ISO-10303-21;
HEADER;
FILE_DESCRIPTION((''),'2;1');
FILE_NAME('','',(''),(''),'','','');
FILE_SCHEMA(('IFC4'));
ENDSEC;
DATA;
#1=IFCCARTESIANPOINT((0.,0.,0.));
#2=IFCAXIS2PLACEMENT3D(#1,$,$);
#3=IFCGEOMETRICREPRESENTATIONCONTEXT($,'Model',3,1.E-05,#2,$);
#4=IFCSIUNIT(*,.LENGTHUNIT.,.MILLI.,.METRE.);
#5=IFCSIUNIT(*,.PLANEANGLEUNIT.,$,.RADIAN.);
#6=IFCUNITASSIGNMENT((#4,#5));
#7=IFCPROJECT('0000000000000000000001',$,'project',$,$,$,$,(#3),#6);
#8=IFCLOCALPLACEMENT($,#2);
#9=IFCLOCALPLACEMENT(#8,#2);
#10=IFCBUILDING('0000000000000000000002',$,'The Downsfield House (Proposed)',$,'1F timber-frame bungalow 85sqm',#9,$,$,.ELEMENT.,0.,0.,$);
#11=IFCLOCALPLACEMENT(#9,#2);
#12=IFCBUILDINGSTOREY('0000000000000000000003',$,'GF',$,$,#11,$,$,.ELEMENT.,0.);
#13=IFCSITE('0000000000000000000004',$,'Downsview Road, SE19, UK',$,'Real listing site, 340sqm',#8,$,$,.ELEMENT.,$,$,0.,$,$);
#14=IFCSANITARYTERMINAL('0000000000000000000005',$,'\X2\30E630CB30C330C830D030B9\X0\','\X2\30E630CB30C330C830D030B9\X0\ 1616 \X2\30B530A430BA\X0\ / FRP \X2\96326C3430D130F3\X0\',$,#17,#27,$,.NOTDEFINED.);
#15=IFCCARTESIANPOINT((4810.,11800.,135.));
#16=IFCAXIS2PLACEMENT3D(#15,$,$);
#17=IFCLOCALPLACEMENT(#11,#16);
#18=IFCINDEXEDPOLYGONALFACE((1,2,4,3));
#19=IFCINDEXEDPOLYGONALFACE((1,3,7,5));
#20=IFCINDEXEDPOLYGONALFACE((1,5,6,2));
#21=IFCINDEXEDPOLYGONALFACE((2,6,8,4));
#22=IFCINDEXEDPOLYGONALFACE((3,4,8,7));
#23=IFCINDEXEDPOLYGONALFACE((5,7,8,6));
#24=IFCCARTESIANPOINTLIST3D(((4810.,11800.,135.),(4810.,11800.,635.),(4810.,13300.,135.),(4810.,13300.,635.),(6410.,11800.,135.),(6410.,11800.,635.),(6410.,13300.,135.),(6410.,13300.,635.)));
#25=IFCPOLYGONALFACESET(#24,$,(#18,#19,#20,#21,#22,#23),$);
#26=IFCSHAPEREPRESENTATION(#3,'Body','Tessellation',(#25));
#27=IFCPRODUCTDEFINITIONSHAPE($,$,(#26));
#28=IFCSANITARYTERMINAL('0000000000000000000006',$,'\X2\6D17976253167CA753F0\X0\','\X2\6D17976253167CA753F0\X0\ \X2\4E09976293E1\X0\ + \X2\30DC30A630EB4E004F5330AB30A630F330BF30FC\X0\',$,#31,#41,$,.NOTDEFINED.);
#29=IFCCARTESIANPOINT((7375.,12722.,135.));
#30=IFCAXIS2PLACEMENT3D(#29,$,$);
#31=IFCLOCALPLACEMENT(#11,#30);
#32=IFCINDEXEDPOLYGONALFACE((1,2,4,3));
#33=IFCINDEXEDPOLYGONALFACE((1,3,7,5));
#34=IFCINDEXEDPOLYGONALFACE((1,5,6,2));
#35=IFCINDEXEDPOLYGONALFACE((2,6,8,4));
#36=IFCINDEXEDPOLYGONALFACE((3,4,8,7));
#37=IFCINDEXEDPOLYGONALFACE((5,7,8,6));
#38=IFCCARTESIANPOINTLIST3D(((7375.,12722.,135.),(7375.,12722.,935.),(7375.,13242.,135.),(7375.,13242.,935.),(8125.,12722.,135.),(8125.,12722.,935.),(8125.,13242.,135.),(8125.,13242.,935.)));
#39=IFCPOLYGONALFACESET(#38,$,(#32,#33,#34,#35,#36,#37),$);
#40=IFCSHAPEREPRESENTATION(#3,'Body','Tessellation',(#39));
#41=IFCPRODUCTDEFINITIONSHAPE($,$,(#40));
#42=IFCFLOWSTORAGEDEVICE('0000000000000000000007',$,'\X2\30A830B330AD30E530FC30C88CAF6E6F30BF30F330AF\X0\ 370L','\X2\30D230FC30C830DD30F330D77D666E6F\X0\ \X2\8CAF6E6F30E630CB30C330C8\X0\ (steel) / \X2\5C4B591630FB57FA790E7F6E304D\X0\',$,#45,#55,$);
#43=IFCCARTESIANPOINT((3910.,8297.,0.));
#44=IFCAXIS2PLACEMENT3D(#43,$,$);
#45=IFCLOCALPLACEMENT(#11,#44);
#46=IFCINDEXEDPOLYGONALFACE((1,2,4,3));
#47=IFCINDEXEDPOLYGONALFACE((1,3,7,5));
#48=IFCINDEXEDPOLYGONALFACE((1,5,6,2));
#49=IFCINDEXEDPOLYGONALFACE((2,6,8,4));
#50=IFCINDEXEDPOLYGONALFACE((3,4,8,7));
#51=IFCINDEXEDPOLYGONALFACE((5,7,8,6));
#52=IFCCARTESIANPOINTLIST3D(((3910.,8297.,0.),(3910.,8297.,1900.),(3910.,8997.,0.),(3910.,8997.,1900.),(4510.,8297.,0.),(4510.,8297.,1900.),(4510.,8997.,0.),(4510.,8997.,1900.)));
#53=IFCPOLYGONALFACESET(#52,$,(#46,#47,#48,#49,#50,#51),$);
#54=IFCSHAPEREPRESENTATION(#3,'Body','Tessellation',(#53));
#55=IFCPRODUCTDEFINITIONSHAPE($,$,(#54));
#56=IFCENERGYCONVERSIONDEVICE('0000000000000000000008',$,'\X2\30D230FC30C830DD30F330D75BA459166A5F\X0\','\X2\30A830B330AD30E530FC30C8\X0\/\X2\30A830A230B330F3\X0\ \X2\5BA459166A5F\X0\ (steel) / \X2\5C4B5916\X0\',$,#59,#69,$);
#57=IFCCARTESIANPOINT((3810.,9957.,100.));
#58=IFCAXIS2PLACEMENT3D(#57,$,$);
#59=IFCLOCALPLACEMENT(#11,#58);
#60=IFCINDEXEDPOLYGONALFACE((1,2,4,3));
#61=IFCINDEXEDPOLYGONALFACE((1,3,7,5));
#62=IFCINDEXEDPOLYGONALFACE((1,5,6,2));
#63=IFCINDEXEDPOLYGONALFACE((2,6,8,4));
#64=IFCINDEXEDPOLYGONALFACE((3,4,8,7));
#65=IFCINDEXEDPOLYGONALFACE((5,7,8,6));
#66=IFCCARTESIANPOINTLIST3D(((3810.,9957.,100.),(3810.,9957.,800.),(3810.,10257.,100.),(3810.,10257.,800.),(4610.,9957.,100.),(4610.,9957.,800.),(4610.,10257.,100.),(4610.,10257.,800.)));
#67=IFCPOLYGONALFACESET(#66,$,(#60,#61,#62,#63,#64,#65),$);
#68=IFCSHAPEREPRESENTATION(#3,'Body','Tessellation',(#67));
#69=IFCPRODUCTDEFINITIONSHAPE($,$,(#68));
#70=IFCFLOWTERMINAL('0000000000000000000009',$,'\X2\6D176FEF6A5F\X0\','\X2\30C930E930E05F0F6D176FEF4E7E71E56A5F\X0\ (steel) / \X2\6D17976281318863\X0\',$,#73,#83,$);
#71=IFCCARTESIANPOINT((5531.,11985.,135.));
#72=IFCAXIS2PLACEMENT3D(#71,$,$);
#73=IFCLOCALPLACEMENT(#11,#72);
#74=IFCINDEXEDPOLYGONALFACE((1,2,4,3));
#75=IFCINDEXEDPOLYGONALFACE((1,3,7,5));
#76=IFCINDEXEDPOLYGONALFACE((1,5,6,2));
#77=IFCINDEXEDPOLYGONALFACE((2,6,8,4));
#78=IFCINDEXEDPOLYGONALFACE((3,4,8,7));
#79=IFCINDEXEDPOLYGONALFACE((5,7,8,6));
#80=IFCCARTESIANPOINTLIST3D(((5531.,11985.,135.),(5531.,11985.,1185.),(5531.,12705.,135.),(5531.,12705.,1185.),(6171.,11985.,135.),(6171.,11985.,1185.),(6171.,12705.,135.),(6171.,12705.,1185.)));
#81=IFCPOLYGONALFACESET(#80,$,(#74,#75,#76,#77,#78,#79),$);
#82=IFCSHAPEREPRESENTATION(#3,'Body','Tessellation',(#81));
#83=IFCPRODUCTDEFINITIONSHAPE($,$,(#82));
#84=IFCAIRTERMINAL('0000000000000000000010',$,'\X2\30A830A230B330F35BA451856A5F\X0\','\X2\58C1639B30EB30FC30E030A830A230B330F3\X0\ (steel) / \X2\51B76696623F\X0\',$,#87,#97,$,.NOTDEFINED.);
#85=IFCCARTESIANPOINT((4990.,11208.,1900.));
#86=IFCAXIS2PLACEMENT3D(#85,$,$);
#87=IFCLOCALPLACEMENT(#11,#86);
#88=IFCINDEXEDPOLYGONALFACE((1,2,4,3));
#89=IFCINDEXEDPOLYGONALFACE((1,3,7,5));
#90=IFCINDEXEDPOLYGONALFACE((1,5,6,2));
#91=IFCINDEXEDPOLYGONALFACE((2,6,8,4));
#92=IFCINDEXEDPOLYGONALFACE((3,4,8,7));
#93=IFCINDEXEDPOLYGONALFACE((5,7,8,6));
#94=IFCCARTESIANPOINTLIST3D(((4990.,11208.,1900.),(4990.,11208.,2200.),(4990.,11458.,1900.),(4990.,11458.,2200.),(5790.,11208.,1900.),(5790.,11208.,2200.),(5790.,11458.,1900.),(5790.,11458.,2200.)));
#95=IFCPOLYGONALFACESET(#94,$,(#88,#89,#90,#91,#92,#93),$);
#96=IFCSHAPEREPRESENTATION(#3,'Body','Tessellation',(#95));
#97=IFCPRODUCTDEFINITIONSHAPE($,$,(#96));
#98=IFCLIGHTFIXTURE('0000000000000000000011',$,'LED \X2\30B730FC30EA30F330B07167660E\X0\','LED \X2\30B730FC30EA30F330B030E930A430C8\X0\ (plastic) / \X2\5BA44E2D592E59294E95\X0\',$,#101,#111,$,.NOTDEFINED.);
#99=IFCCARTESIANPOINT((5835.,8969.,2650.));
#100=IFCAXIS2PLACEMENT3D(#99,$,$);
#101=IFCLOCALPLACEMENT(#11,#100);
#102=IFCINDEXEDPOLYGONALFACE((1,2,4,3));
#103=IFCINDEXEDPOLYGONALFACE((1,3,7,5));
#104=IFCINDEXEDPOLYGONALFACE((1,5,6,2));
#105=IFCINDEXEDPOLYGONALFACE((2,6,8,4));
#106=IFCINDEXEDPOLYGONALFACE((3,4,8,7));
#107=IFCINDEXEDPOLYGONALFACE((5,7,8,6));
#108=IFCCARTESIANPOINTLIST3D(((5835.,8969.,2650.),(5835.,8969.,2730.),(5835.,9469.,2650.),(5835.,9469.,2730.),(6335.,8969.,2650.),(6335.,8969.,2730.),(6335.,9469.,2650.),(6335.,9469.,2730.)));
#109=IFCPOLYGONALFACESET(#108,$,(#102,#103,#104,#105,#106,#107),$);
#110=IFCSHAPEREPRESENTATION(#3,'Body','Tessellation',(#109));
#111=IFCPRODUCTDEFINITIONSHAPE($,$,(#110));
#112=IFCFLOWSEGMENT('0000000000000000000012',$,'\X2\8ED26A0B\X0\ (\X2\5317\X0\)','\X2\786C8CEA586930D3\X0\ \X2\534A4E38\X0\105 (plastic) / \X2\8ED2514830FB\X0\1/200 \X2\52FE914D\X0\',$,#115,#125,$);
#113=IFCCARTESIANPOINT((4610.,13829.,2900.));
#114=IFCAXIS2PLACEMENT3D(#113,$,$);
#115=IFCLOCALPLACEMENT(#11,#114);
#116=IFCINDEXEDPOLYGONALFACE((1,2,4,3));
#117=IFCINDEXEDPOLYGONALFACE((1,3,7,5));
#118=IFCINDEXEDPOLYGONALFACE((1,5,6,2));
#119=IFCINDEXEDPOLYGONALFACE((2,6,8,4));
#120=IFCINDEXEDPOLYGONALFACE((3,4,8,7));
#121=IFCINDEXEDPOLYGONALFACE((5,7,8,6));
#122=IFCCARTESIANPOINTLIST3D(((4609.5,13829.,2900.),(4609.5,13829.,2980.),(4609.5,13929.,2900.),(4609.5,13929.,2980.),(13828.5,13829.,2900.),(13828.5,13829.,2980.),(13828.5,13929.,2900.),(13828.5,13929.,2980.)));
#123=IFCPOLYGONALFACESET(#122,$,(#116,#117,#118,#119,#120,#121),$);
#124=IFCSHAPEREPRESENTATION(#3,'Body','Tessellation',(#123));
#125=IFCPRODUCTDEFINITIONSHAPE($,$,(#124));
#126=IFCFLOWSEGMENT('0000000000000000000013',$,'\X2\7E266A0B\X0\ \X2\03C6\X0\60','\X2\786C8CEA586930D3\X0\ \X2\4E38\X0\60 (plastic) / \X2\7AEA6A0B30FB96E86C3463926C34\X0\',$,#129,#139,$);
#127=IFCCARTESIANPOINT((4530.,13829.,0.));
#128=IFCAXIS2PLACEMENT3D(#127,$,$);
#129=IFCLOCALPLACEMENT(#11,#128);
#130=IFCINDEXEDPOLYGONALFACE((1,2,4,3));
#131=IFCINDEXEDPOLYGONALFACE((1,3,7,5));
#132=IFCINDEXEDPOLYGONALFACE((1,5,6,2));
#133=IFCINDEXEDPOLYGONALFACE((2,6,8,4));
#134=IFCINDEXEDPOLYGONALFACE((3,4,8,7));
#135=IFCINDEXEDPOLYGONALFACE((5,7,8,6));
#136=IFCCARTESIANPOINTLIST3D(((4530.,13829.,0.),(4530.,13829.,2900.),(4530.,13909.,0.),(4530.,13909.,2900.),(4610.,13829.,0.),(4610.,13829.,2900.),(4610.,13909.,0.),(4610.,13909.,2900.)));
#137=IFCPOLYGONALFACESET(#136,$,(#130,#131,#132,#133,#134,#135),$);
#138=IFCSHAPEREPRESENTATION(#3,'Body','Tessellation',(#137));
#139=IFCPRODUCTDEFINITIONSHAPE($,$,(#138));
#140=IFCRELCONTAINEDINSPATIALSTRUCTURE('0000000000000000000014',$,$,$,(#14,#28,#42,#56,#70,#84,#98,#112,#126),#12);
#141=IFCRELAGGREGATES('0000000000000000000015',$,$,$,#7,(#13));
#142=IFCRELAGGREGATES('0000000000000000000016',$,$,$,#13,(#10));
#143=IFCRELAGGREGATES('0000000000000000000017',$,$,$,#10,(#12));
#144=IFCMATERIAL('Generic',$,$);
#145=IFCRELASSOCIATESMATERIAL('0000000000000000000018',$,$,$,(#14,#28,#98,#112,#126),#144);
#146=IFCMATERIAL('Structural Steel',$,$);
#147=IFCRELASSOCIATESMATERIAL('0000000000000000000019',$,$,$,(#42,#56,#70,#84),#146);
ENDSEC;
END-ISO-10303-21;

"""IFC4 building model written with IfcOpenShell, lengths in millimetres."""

from ifc_helpers import new_model, si_unit, frame, frame_2d, origin, place, context, project, spatial, rectangle, extrude, material, element, save


model = new_model("IFC4")

# Units and contexts
model_context = context("Model", 3, precision=1e-05, world=origin())
ifc_project = project(units=[si_unit("LENGTHUNIT", "METRE", prefix="MILLI"), si_unit("PLANEANGLEUNIT", "RADIAN")], contexts=[model_context])

# Site, building, storey
site_placement = place(None, origin())
site = spatial("IfcSite", under=ifc_project, at=site_placement, Name="Downsview Road, SE19, UK", ObjectType="Real listing site, 340sqm", CompositionType="ELEMENT", RefElevation=0.0)
building_placement = place(site_placement, origin())
building = spatial("IfcBuilding", under=site, at=building_placement, Name="The Downsfield House (Proposed)", ObjectType="1F timber-frame bungalow 85sqm", CompositionType="ELEMENT", ElevationOfRefHeight=0.0, ElevationOfTerrain=0.0)
storey_placement = place(building_placement, origin())
storey = spatial("IfcBuildingStorey", under=building, at=storey_placement, Name="GF", CompositionType="ELEMENT", Elevation=0.0)

# Shared definitions
ifc_material_1 = material(Name="Structural Steel")

# Shared definitions
ifc_material_2 = material(Name="Generic")

# Sanitary terminals
sanitary_terminal_1_placement = place(storey_placement, frame((4810.0, 11800.0, 135.0)))
element("IfcSanitaryTerminal", 1, at=sanitary_terminal_1_placement, inside=storey, material=ifc_material_2, Name="ユニットバス", Description="ユニットバス 1616 サイズ / FRP 防水パン", PredefinedType="NOTDEFINED", context=model_context, shape_type="SweptSolid", body=[
    extrude(rectangle(XDim=1600.0, YDim=1500.0, at=frame_2d((800.0, 750.0))), frame((4810.0, 11800.0, 135.0)), (0.0, 0.0, 1.0), 500.0),
])
sanitary_terminal_2_placement = place(storey_placement, frame((7375.0, 12722.0, 135.0)))
element("IfcSanitaryTerminal", 2, at=sanitary_terminal_2_placement, inside=storey, material=ifc_material_2, Name="洗面化粧台", Description="洗面化粧台 三面鏡 + ボウル一体カウンター", PredefinedType="NOTDEFINED", context=model_context, shape_type="SweptSolid", body=[
    extrude(rectangle(XDim=750.0, YDim=520.0, at=frame_2d((375.0, 260.0))), frame((7375.0, 12722.0, 135.0)), (0.0, 0.0, 1.0), 800.0),
])

# Flow storage device
flow_storage_device_placement = place(storey_placement, frame((3910.0, 8297.0, 0.0)))
element("IfcFlowStorageDevice", 3, at=flow_storage_device_placement, inside=storey, material=ifc_material_1, Name="エコキュート貯湯タンク 370L", Description="ヒートポンプ給湯 貯湯ユニット (steel) / 屋外・基礎置き", context=model_context, shape_type="SweptSolid", body=[
    extrude(rectangle(XDim=600.0, YDim=700.0, at=frame_2d((300.0, 350.0))), frame((3910.0, 8297.0, 0.0)), (0.0, 0.0, 1.0), 1900.0),
])

# Energy conversion device
energy_conversion_device_placement = place(storey_placement, frame((3810.0, 9957.0, 100.0)))
element("IfcEnergyConversionDevice", 4, at=energy_conversion_device_placement, inside=storey, material=ifc_material_1, Name="ヒートポンプ室外機", Description="エコキュート/エアコン 室外機 (steel) / 屋外", context=model_context, shape_type="SweptSolid", body=[
    extrude(rectangle(XDim=800.0, YDim=300.0, at=frame_2d((400.0, 150.0))), frame((3810.0, 9957.0, 100.0)), (0.0, 0.0, 1.0), 700.0),
])

# Flow terminal
flow_terminal_placement = place(storey_placement, frame((5531.0, 11985.0, 135.0)))
element("IfcFlowTerminal", 5, at=flow_terminal_placement, inside=storey, material=ifc_material_1, Name="洗濯機", Description="ドラム式洗濯乾燥機 (steel) / 洗面脱衣", context=model_context, shape_type="SweptSolid", body=[
    extrude(rectangle(XDim=640.0, YDim=720.0, at=frame_2d((320.0, 360.0))), frame((5531.0, 11985.0, 135.0)), (0.0, 0.0, 1.0), 1050.0),
])

# Air terminal
air_terminal_placement = place(storey_placement, frame((4990.0, 11208.0, 1900.0)))
element("IfcAirTerminal", 6, at=air_terminal_placement, inside=storey, material=ifc_material_1, Name="エアコン室内機", Description="壁掛ルームエアコン (steel) / 冷暖房", PredefinedType="NOTDEFINED", context=model_context, shape_type="SweptSolid", body=[
    extrude(rectangle(XDim=800.0, YDim=250.0, at=frame_2d((400.0, 125.0))), frame((4990.0, 11208.0, 1900.0)), (0.0, 0.0, 1.0), 300.0),
])

# Light fixture
light_fixture_placement = place(storey_placement, frame((5835.0, 8969.0, 2650.0)))
element("IfcLightFixture", 7, at=light_fixture_placement, inside=storey, material=ifc_material_2, Name="LED シーリング照明", Description="LED シーリングライト (plastic) / 室中央天井", PredefinedType="NOTDEFINED", context=model_context, shape_type="SweptSolid", body=[
    extrude(rectangle(XDim=500.0, YDim=500.0, at=frame_2d((250.0, 250.0))), frame((5835.0, 8969.0, 2650.0)), (0.0, 0.0, 1.0), 80.0),
])

# Flow segments
flow_segment_1_placement = place(storey_placement, frame((4610.0, 13829.0, 2900.0)))
element("IfcFlowSegment", 8, at=flow_segment_1_placement, inside=storey, material=ifc_material_2, Name="軒樋 (北)", Description="硬質塩ビ 半丸105 (plastic) / 軒先・1/200 勾配", context=model_context, shape_type="SweptSolid", body=[
    extrude(rectangle(XDim=9219.0, YDim=100.0, at=frame_2d((4609.0, 50.0))), frame((4610.0, 13829.0, 2900.0)), (0.0, 0.0, 1.0), 80.0),
])
flow_segment_2_placement = place(storey_placement, frame((4530.0, 13829.0, 0.0)))
element("IfcFlowSegment", 9, at=flow_segment_2_placement, inside=storey, material=ifc_material_2, Name="縦樋 φ60", Description="硬質塩ビ 丸60 (plastic) / 竪樋・雨水排水", context=model_context, shape_type="SweptSolid", body=[
    extrude(rectangle(XDim=80.0, YDim=80.0, at=frame_2d((40.0, 40.0))), frame((4530.0, 13829.0, 0.0)), (0.0, 0.0, 1.0), 2900.0),
])

save(model, "model.ifc")
